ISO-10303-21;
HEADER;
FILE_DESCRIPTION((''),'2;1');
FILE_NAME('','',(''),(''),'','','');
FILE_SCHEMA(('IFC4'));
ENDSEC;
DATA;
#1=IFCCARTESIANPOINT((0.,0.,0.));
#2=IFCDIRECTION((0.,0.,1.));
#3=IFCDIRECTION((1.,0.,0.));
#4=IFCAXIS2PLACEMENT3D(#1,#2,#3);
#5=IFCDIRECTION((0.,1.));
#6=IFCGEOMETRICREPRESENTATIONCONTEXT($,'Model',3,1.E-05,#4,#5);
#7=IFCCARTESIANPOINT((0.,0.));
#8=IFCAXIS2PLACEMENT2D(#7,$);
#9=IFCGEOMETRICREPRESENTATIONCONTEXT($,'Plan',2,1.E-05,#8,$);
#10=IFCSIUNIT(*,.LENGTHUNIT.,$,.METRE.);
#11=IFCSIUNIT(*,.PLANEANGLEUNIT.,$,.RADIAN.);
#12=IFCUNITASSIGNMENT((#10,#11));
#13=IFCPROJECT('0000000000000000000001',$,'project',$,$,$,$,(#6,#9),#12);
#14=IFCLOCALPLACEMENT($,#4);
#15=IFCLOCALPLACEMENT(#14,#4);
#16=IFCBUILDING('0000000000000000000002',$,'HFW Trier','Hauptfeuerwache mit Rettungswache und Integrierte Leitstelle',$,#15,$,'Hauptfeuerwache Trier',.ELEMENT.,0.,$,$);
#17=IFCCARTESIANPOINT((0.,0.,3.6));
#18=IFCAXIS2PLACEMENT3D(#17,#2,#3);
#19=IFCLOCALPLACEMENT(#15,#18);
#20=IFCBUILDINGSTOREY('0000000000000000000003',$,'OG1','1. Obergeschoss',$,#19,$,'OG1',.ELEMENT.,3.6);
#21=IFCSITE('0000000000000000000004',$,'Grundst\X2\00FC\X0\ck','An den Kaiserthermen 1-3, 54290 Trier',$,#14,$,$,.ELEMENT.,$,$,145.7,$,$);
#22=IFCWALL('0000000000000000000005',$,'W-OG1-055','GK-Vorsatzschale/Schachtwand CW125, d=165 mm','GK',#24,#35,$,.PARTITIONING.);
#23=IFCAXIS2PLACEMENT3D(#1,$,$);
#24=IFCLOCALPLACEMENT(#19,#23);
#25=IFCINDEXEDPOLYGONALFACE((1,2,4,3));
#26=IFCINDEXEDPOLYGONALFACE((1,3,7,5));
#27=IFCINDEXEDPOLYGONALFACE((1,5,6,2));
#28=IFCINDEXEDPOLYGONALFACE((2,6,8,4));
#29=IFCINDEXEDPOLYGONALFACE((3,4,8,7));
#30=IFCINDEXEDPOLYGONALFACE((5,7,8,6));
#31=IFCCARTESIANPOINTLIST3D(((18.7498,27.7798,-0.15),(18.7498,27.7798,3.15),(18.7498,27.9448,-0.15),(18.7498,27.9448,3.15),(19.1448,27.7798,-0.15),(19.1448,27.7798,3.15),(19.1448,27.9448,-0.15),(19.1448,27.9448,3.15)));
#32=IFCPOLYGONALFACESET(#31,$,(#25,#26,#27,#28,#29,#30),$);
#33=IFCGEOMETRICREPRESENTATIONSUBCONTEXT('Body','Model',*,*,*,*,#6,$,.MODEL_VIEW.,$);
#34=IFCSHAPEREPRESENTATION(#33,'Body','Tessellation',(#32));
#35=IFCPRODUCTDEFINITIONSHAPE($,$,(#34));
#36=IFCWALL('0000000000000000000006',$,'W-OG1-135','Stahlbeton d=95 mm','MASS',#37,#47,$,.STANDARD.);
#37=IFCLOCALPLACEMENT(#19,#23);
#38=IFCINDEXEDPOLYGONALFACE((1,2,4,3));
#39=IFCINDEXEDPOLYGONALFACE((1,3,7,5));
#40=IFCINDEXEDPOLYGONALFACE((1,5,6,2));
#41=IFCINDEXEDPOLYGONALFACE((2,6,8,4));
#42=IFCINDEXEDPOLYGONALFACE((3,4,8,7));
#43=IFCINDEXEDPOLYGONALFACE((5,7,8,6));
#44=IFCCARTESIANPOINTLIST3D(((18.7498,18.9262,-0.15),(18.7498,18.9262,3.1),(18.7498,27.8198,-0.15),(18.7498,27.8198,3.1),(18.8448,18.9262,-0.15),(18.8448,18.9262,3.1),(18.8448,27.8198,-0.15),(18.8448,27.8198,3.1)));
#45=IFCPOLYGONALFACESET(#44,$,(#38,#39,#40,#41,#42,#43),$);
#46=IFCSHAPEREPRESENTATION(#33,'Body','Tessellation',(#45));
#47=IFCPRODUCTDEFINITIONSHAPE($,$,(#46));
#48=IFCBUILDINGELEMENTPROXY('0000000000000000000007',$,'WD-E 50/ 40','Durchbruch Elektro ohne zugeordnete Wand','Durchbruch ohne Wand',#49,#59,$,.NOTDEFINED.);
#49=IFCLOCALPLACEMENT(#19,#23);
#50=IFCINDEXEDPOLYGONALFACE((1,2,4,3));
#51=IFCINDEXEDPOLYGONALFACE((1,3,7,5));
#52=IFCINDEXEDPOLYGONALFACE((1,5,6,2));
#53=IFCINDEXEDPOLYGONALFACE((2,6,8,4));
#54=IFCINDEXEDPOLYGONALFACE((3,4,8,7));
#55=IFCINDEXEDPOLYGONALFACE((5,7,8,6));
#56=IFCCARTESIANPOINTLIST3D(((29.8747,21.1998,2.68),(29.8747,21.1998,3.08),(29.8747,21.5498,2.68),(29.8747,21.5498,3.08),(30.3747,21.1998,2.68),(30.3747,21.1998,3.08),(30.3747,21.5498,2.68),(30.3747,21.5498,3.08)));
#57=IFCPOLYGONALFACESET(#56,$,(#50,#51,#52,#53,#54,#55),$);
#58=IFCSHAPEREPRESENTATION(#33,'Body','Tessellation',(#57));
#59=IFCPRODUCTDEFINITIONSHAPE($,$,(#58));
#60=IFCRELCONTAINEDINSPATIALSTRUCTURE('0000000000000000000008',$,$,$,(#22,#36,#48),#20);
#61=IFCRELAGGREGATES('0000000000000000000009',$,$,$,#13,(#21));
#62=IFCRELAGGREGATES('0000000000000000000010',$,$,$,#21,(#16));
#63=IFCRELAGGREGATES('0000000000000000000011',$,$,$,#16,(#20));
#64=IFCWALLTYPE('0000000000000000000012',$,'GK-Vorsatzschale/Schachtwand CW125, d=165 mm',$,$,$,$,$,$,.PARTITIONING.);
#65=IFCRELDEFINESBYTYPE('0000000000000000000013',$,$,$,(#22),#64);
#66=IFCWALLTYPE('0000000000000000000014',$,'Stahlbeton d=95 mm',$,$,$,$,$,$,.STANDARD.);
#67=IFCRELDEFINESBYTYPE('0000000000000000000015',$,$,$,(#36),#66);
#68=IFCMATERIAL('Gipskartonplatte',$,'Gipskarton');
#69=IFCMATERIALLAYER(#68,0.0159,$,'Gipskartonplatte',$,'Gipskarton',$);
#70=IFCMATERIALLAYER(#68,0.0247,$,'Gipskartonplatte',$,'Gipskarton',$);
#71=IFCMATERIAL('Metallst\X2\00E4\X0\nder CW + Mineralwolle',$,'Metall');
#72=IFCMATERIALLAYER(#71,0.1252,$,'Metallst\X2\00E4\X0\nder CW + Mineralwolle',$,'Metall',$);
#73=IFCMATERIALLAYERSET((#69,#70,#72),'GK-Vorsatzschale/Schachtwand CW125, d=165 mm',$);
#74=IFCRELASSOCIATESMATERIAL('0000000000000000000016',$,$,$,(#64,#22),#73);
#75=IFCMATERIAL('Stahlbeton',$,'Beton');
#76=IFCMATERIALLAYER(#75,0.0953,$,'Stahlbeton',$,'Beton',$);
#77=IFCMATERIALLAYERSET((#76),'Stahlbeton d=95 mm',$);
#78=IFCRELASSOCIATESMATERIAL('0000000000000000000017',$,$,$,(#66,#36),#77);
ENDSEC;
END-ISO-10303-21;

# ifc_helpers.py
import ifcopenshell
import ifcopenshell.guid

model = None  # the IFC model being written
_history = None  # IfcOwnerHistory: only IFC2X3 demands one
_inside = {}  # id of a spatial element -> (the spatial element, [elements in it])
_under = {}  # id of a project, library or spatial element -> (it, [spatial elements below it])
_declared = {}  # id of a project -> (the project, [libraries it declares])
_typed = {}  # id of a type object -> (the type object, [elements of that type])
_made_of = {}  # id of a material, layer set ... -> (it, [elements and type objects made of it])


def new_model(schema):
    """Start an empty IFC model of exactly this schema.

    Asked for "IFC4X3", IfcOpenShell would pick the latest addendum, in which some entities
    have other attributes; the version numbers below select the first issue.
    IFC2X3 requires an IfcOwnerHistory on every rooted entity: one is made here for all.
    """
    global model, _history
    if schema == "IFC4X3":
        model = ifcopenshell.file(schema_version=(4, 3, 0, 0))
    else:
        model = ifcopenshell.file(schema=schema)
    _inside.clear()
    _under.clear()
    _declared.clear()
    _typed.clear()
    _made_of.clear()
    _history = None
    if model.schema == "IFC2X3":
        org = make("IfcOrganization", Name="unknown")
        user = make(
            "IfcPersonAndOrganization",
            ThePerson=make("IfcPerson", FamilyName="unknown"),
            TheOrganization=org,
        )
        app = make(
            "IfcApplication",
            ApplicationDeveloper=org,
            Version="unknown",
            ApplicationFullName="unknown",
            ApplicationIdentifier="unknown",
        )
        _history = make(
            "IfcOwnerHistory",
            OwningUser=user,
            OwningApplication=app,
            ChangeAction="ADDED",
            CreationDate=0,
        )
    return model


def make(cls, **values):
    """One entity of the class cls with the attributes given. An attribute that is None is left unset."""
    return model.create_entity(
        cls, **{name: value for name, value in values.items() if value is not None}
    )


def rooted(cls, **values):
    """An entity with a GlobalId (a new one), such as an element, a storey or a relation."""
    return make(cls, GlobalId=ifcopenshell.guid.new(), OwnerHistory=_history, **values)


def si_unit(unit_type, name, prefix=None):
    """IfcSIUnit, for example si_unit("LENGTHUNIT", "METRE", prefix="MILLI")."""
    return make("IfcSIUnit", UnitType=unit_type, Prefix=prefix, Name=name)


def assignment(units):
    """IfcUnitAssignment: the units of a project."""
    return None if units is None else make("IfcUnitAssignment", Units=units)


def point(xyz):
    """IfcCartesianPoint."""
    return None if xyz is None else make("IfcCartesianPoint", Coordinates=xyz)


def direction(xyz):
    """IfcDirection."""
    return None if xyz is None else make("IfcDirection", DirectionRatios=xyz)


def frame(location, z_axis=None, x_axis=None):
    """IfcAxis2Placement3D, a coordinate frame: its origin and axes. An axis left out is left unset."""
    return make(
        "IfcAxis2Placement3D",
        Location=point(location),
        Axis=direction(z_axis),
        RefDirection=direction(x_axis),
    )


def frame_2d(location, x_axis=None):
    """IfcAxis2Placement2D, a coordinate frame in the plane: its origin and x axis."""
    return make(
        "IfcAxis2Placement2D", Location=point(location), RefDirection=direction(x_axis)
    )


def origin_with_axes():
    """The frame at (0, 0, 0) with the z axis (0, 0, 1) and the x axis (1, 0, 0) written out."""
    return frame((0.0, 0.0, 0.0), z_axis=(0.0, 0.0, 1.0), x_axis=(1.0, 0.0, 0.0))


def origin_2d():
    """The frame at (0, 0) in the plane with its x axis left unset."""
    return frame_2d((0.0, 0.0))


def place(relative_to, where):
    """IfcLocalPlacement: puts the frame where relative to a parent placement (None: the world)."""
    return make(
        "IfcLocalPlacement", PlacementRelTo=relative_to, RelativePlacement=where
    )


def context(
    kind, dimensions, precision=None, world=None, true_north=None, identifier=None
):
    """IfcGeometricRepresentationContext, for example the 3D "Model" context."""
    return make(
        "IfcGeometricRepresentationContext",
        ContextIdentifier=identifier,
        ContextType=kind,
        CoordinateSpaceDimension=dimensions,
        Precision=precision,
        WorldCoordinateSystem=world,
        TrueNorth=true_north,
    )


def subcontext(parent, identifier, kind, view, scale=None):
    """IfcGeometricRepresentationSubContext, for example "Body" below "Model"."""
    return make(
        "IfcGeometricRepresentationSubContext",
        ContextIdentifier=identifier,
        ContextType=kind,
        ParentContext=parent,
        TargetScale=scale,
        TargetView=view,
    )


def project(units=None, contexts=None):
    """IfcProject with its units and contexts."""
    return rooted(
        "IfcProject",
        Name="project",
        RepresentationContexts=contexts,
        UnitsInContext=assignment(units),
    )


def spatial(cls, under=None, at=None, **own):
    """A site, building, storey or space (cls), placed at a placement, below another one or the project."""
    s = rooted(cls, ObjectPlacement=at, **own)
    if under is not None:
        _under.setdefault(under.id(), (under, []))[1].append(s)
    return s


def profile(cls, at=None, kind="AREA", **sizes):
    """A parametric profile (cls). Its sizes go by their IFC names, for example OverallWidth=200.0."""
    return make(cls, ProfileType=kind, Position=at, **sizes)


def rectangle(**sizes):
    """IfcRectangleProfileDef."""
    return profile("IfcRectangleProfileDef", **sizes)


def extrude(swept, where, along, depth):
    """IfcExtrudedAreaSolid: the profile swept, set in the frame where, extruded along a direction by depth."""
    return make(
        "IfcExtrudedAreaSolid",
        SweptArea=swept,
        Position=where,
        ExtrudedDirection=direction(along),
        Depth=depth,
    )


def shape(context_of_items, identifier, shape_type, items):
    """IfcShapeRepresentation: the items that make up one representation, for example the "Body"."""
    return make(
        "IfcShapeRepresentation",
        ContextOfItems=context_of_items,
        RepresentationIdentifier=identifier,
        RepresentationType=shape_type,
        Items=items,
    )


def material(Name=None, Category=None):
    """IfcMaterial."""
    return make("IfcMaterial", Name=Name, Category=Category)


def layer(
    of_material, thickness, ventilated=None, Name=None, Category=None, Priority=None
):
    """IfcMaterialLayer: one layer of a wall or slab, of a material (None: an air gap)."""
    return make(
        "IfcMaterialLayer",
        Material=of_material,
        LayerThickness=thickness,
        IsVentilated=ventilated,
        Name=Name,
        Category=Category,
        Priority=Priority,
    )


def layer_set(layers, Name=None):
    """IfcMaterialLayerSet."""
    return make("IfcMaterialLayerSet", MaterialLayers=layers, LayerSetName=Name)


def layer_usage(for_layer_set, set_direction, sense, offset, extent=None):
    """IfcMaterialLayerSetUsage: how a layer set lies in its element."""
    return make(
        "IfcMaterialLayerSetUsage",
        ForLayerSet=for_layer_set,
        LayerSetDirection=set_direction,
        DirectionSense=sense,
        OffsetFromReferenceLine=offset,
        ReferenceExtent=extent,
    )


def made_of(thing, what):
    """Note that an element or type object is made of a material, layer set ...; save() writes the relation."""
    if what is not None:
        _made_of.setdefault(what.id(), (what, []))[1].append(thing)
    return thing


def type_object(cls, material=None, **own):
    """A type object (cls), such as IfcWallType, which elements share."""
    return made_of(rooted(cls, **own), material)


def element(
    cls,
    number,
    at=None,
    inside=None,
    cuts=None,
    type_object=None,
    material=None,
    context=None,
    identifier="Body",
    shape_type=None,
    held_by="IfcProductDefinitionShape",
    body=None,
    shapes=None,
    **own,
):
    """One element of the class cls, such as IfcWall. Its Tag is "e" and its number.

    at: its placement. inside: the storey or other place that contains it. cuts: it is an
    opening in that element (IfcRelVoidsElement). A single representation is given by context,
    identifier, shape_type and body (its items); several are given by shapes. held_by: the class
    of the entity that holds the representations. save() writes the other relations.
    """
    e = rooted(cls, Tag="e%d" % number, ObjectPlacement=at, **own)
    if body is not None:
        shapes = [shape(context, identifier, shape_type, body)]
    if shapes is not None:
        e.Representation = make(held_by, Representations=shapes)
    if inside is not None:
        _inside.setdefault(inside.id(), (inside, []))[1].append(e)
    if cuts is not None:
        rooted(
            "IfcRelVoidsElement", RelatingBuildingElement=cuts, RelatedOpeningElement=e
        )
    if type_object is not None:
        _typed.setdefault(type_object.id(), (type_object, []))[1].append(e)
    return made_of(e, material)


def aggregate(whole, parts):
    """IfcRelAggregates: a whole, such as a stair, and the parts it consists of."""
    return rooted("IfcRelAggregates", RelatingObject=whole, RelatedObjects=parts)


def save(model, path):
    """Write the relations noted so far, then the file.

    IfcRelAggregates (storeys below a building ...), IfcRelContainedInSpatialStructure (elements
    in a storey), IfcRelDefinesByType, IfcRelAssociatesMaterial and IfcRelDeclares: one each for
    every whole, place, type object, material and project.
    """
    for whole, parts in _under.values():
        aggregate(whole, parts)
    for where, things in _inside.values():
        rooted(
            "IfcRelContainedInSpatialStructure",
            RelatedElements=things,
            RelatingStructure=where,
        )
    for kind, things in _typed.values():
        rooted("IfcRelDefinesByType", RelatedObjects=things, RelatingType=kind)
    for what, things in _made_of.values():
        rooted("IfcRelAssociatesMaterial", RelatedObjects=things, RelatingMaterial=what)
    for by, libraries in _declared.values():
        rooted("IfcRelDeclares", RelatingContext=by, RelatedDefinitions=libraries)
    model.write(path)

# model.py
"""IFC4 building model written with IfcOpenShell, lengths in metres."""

from ifc_helpers import new_model, si_unit, direction, frame, frame_2d, origin_with_axes, origin_2d, place, context, subcontext, project, spatial, rectangle, extrude, material, layer, layer_set, layer_usage, type_object, element, save


model = new_model("IFC4")

# Units and contexts
model_context = context("Model", 3, precision=1e-05, world=origin_with_axes(), true_north=direction((0.0, 1.0)))
plan_context = context("Plan", 2, precision=1e-05, world=origin_2d())
body_context = subcontext(model_context, "Body", "Model", "MODEL_VIEW")
ifc_project = project(units=[si_unit("LENGTHUNIT", "METRE"), si_unit("PLANEANGLEUNIT", "RADIAN")], contexts=[model_context, plan_context])

# Site, building, storey
site_placement = place(None, origin_with_axes())
site = spatial("IfcSite", under=ifc_project, at=site_placement, Name="Grundstück", Description="An den Kaiserthermen 1-3, 54290 Trier", CompositionType="ELEMENT", RefElevation=145.7)
building_placement = place(site_placement, origin_with_axes())
building = spatial("IfcBuilding", under=site, at=building_placement, Name="HFW Trier", Description="Hauptfeuerwache mit Rettungswache und Integrierte Leitstelle", LongName="Hauptfeuerwache Trier", CompositionType="ELEMENT", ElevationOfRefHeight=0.0)
storey_placement = place(building_placement, frame((0.0, 0.0, 3.6), z_axis=(0.0, 0.0, 1.0), x_axis=(1.0, 0.0, 0.0)))
storey = spatial("IfcBuildingStorey", under=building, at=storey_placement, Name="OG1", Description="1. Obergeschoss", LongName="OG1", CompositionType="ELEMENT", Elevation=3.6)

# Shared definitions
ifc_material_1 = material(Name="Stahlbeton", Category="Beton")

# Shared definitions
ifc_material_2 = material(Name="Metallständer CW + Mineralwolle", Category="Metall")

# Shared definitions
ifc_material_3 = material(Name="Gipskartonplatte", Category="Gipskarton")

# Wall
ifc_layer_1 = layer(ifc_material_3, 0.0159, Name="Gipskartonplatte", Category="Gipskarton")
ifc_layer_2 = layer(ifc_material_3, 0.0247, Name="Gipskartonplatte", Category="Gipskarton")
ifc_layer_3 = layer(ifc_material_2, 0.1252, Name="Metallständer CW + Mineralwolle", Category="Metall")
ifc_layer_set_1 = layer_set([ifc_layer_1, ifc_layer_2, ifc_layer_3], Name="GK-Vorsatzschale/Schachtwand CW125, d=165 mm")
wall_type_1 = type_object("IfcWallType", Name="GK-Vorsatzschale/Schachtwand CW125, d=165 mm", PredefinedType="PARTITIONING", material=ifc_layer_set_1)
ifc_layer_usage_1 = layer_usage(ifc_layer_set_1, "AXIS2", "POSITIVE", -0.0825)
wall_1_placement = place(storey_placement, frame((18.7498, 27.8623, -0.15), z_axis=(0.0, 0.0, 1.0), x_axis=(1.0, 0.0, 0.0)))
element("IfcWall", 1, at=wall_1_placement, inside=storey, type_object=wall_type_1, material=ifc_layer_usage_1, Name="W-OG1-055", Description="GK-Vorsatzschale/Schachtwand CW125, d=165 mm", ObjectType="GK", PredefinedType="PARTITIONING", context=body_context, shape_type="SweptSolid", body=[
    extrude(rectangle(XDim=0.395, YDim=0.165, at=frame_2d((0.1975, 0.0))), origin_with_axes(), (0.0, 0.0, 1.0), 3.3),
])

# Wall
ifc_layer_4 = layer(ifc_material_1, 0.0953, Name="Stahlbeton", Category="Beton")
ifc_layer_set_2 = layer_set([ifc_layer_4], Name="Stahlbeton d=95 mm")
ifc_layer_usage_2 = layer_usage(ifc_layer_set_2, "AXIS2", "POSITIVE", -0.0475)
wall_type_2 = type_object("IfcWallType", Name="Stahlbeton d=95 mm", PredefinedType="STANDARD", material=ifc_layer_set_2)
wall_2_placement = place(storey_placement, frame((18.7973, 27.8198, -0.15), z_axis=(0.0, 0.0, 1.0), x_axis=(0.0, -1.0, 0.0)))
element("IfcWall", 2, at=wall_2_placement, inside=storey, type_object=wall_type_2, material=ifc_layer_usage_2, Name="W-OG1-135", Description="Stahlbeton d=95 mm", ObjectType="MASS", PredefinedType="STANDARD", context=body_context, shape_type="SweptSolid", body=[
    extrude(rectangle(XDim=8.8936, YDim=0.095, at=frame_2d((4.4468, 0.0))), origin_with_axes(), (0.0, 0.0, 1.0), 3.25),
])

# Building element proxy
proxy_placement = place(storey_placement, frame((30.1247, 21.3748, 2.68), z_axis=(0.0, 0.0, 1.0), x_axis=(1.0, 0.0, 0.0)))
element("IfcBuildingElementProxy", 3, at=proxy_placement, inside=storey, Name="WD-E 50/ 40", Description="Durchbruch Elektro ohne zugeordnete Wand", ObjectType="Durchbruch ohne Wand", PredefinedType="NOTDEFINED", context=body_context, shape_type="SweptSolid", body=[
    extrude(rectangle(XDim=0.5, YDim=0.35, at=origin_2d()), origin_with_axes(), (0.0, 0.0, 1.0), 0.4),
])

save(model, "model.ifc")
